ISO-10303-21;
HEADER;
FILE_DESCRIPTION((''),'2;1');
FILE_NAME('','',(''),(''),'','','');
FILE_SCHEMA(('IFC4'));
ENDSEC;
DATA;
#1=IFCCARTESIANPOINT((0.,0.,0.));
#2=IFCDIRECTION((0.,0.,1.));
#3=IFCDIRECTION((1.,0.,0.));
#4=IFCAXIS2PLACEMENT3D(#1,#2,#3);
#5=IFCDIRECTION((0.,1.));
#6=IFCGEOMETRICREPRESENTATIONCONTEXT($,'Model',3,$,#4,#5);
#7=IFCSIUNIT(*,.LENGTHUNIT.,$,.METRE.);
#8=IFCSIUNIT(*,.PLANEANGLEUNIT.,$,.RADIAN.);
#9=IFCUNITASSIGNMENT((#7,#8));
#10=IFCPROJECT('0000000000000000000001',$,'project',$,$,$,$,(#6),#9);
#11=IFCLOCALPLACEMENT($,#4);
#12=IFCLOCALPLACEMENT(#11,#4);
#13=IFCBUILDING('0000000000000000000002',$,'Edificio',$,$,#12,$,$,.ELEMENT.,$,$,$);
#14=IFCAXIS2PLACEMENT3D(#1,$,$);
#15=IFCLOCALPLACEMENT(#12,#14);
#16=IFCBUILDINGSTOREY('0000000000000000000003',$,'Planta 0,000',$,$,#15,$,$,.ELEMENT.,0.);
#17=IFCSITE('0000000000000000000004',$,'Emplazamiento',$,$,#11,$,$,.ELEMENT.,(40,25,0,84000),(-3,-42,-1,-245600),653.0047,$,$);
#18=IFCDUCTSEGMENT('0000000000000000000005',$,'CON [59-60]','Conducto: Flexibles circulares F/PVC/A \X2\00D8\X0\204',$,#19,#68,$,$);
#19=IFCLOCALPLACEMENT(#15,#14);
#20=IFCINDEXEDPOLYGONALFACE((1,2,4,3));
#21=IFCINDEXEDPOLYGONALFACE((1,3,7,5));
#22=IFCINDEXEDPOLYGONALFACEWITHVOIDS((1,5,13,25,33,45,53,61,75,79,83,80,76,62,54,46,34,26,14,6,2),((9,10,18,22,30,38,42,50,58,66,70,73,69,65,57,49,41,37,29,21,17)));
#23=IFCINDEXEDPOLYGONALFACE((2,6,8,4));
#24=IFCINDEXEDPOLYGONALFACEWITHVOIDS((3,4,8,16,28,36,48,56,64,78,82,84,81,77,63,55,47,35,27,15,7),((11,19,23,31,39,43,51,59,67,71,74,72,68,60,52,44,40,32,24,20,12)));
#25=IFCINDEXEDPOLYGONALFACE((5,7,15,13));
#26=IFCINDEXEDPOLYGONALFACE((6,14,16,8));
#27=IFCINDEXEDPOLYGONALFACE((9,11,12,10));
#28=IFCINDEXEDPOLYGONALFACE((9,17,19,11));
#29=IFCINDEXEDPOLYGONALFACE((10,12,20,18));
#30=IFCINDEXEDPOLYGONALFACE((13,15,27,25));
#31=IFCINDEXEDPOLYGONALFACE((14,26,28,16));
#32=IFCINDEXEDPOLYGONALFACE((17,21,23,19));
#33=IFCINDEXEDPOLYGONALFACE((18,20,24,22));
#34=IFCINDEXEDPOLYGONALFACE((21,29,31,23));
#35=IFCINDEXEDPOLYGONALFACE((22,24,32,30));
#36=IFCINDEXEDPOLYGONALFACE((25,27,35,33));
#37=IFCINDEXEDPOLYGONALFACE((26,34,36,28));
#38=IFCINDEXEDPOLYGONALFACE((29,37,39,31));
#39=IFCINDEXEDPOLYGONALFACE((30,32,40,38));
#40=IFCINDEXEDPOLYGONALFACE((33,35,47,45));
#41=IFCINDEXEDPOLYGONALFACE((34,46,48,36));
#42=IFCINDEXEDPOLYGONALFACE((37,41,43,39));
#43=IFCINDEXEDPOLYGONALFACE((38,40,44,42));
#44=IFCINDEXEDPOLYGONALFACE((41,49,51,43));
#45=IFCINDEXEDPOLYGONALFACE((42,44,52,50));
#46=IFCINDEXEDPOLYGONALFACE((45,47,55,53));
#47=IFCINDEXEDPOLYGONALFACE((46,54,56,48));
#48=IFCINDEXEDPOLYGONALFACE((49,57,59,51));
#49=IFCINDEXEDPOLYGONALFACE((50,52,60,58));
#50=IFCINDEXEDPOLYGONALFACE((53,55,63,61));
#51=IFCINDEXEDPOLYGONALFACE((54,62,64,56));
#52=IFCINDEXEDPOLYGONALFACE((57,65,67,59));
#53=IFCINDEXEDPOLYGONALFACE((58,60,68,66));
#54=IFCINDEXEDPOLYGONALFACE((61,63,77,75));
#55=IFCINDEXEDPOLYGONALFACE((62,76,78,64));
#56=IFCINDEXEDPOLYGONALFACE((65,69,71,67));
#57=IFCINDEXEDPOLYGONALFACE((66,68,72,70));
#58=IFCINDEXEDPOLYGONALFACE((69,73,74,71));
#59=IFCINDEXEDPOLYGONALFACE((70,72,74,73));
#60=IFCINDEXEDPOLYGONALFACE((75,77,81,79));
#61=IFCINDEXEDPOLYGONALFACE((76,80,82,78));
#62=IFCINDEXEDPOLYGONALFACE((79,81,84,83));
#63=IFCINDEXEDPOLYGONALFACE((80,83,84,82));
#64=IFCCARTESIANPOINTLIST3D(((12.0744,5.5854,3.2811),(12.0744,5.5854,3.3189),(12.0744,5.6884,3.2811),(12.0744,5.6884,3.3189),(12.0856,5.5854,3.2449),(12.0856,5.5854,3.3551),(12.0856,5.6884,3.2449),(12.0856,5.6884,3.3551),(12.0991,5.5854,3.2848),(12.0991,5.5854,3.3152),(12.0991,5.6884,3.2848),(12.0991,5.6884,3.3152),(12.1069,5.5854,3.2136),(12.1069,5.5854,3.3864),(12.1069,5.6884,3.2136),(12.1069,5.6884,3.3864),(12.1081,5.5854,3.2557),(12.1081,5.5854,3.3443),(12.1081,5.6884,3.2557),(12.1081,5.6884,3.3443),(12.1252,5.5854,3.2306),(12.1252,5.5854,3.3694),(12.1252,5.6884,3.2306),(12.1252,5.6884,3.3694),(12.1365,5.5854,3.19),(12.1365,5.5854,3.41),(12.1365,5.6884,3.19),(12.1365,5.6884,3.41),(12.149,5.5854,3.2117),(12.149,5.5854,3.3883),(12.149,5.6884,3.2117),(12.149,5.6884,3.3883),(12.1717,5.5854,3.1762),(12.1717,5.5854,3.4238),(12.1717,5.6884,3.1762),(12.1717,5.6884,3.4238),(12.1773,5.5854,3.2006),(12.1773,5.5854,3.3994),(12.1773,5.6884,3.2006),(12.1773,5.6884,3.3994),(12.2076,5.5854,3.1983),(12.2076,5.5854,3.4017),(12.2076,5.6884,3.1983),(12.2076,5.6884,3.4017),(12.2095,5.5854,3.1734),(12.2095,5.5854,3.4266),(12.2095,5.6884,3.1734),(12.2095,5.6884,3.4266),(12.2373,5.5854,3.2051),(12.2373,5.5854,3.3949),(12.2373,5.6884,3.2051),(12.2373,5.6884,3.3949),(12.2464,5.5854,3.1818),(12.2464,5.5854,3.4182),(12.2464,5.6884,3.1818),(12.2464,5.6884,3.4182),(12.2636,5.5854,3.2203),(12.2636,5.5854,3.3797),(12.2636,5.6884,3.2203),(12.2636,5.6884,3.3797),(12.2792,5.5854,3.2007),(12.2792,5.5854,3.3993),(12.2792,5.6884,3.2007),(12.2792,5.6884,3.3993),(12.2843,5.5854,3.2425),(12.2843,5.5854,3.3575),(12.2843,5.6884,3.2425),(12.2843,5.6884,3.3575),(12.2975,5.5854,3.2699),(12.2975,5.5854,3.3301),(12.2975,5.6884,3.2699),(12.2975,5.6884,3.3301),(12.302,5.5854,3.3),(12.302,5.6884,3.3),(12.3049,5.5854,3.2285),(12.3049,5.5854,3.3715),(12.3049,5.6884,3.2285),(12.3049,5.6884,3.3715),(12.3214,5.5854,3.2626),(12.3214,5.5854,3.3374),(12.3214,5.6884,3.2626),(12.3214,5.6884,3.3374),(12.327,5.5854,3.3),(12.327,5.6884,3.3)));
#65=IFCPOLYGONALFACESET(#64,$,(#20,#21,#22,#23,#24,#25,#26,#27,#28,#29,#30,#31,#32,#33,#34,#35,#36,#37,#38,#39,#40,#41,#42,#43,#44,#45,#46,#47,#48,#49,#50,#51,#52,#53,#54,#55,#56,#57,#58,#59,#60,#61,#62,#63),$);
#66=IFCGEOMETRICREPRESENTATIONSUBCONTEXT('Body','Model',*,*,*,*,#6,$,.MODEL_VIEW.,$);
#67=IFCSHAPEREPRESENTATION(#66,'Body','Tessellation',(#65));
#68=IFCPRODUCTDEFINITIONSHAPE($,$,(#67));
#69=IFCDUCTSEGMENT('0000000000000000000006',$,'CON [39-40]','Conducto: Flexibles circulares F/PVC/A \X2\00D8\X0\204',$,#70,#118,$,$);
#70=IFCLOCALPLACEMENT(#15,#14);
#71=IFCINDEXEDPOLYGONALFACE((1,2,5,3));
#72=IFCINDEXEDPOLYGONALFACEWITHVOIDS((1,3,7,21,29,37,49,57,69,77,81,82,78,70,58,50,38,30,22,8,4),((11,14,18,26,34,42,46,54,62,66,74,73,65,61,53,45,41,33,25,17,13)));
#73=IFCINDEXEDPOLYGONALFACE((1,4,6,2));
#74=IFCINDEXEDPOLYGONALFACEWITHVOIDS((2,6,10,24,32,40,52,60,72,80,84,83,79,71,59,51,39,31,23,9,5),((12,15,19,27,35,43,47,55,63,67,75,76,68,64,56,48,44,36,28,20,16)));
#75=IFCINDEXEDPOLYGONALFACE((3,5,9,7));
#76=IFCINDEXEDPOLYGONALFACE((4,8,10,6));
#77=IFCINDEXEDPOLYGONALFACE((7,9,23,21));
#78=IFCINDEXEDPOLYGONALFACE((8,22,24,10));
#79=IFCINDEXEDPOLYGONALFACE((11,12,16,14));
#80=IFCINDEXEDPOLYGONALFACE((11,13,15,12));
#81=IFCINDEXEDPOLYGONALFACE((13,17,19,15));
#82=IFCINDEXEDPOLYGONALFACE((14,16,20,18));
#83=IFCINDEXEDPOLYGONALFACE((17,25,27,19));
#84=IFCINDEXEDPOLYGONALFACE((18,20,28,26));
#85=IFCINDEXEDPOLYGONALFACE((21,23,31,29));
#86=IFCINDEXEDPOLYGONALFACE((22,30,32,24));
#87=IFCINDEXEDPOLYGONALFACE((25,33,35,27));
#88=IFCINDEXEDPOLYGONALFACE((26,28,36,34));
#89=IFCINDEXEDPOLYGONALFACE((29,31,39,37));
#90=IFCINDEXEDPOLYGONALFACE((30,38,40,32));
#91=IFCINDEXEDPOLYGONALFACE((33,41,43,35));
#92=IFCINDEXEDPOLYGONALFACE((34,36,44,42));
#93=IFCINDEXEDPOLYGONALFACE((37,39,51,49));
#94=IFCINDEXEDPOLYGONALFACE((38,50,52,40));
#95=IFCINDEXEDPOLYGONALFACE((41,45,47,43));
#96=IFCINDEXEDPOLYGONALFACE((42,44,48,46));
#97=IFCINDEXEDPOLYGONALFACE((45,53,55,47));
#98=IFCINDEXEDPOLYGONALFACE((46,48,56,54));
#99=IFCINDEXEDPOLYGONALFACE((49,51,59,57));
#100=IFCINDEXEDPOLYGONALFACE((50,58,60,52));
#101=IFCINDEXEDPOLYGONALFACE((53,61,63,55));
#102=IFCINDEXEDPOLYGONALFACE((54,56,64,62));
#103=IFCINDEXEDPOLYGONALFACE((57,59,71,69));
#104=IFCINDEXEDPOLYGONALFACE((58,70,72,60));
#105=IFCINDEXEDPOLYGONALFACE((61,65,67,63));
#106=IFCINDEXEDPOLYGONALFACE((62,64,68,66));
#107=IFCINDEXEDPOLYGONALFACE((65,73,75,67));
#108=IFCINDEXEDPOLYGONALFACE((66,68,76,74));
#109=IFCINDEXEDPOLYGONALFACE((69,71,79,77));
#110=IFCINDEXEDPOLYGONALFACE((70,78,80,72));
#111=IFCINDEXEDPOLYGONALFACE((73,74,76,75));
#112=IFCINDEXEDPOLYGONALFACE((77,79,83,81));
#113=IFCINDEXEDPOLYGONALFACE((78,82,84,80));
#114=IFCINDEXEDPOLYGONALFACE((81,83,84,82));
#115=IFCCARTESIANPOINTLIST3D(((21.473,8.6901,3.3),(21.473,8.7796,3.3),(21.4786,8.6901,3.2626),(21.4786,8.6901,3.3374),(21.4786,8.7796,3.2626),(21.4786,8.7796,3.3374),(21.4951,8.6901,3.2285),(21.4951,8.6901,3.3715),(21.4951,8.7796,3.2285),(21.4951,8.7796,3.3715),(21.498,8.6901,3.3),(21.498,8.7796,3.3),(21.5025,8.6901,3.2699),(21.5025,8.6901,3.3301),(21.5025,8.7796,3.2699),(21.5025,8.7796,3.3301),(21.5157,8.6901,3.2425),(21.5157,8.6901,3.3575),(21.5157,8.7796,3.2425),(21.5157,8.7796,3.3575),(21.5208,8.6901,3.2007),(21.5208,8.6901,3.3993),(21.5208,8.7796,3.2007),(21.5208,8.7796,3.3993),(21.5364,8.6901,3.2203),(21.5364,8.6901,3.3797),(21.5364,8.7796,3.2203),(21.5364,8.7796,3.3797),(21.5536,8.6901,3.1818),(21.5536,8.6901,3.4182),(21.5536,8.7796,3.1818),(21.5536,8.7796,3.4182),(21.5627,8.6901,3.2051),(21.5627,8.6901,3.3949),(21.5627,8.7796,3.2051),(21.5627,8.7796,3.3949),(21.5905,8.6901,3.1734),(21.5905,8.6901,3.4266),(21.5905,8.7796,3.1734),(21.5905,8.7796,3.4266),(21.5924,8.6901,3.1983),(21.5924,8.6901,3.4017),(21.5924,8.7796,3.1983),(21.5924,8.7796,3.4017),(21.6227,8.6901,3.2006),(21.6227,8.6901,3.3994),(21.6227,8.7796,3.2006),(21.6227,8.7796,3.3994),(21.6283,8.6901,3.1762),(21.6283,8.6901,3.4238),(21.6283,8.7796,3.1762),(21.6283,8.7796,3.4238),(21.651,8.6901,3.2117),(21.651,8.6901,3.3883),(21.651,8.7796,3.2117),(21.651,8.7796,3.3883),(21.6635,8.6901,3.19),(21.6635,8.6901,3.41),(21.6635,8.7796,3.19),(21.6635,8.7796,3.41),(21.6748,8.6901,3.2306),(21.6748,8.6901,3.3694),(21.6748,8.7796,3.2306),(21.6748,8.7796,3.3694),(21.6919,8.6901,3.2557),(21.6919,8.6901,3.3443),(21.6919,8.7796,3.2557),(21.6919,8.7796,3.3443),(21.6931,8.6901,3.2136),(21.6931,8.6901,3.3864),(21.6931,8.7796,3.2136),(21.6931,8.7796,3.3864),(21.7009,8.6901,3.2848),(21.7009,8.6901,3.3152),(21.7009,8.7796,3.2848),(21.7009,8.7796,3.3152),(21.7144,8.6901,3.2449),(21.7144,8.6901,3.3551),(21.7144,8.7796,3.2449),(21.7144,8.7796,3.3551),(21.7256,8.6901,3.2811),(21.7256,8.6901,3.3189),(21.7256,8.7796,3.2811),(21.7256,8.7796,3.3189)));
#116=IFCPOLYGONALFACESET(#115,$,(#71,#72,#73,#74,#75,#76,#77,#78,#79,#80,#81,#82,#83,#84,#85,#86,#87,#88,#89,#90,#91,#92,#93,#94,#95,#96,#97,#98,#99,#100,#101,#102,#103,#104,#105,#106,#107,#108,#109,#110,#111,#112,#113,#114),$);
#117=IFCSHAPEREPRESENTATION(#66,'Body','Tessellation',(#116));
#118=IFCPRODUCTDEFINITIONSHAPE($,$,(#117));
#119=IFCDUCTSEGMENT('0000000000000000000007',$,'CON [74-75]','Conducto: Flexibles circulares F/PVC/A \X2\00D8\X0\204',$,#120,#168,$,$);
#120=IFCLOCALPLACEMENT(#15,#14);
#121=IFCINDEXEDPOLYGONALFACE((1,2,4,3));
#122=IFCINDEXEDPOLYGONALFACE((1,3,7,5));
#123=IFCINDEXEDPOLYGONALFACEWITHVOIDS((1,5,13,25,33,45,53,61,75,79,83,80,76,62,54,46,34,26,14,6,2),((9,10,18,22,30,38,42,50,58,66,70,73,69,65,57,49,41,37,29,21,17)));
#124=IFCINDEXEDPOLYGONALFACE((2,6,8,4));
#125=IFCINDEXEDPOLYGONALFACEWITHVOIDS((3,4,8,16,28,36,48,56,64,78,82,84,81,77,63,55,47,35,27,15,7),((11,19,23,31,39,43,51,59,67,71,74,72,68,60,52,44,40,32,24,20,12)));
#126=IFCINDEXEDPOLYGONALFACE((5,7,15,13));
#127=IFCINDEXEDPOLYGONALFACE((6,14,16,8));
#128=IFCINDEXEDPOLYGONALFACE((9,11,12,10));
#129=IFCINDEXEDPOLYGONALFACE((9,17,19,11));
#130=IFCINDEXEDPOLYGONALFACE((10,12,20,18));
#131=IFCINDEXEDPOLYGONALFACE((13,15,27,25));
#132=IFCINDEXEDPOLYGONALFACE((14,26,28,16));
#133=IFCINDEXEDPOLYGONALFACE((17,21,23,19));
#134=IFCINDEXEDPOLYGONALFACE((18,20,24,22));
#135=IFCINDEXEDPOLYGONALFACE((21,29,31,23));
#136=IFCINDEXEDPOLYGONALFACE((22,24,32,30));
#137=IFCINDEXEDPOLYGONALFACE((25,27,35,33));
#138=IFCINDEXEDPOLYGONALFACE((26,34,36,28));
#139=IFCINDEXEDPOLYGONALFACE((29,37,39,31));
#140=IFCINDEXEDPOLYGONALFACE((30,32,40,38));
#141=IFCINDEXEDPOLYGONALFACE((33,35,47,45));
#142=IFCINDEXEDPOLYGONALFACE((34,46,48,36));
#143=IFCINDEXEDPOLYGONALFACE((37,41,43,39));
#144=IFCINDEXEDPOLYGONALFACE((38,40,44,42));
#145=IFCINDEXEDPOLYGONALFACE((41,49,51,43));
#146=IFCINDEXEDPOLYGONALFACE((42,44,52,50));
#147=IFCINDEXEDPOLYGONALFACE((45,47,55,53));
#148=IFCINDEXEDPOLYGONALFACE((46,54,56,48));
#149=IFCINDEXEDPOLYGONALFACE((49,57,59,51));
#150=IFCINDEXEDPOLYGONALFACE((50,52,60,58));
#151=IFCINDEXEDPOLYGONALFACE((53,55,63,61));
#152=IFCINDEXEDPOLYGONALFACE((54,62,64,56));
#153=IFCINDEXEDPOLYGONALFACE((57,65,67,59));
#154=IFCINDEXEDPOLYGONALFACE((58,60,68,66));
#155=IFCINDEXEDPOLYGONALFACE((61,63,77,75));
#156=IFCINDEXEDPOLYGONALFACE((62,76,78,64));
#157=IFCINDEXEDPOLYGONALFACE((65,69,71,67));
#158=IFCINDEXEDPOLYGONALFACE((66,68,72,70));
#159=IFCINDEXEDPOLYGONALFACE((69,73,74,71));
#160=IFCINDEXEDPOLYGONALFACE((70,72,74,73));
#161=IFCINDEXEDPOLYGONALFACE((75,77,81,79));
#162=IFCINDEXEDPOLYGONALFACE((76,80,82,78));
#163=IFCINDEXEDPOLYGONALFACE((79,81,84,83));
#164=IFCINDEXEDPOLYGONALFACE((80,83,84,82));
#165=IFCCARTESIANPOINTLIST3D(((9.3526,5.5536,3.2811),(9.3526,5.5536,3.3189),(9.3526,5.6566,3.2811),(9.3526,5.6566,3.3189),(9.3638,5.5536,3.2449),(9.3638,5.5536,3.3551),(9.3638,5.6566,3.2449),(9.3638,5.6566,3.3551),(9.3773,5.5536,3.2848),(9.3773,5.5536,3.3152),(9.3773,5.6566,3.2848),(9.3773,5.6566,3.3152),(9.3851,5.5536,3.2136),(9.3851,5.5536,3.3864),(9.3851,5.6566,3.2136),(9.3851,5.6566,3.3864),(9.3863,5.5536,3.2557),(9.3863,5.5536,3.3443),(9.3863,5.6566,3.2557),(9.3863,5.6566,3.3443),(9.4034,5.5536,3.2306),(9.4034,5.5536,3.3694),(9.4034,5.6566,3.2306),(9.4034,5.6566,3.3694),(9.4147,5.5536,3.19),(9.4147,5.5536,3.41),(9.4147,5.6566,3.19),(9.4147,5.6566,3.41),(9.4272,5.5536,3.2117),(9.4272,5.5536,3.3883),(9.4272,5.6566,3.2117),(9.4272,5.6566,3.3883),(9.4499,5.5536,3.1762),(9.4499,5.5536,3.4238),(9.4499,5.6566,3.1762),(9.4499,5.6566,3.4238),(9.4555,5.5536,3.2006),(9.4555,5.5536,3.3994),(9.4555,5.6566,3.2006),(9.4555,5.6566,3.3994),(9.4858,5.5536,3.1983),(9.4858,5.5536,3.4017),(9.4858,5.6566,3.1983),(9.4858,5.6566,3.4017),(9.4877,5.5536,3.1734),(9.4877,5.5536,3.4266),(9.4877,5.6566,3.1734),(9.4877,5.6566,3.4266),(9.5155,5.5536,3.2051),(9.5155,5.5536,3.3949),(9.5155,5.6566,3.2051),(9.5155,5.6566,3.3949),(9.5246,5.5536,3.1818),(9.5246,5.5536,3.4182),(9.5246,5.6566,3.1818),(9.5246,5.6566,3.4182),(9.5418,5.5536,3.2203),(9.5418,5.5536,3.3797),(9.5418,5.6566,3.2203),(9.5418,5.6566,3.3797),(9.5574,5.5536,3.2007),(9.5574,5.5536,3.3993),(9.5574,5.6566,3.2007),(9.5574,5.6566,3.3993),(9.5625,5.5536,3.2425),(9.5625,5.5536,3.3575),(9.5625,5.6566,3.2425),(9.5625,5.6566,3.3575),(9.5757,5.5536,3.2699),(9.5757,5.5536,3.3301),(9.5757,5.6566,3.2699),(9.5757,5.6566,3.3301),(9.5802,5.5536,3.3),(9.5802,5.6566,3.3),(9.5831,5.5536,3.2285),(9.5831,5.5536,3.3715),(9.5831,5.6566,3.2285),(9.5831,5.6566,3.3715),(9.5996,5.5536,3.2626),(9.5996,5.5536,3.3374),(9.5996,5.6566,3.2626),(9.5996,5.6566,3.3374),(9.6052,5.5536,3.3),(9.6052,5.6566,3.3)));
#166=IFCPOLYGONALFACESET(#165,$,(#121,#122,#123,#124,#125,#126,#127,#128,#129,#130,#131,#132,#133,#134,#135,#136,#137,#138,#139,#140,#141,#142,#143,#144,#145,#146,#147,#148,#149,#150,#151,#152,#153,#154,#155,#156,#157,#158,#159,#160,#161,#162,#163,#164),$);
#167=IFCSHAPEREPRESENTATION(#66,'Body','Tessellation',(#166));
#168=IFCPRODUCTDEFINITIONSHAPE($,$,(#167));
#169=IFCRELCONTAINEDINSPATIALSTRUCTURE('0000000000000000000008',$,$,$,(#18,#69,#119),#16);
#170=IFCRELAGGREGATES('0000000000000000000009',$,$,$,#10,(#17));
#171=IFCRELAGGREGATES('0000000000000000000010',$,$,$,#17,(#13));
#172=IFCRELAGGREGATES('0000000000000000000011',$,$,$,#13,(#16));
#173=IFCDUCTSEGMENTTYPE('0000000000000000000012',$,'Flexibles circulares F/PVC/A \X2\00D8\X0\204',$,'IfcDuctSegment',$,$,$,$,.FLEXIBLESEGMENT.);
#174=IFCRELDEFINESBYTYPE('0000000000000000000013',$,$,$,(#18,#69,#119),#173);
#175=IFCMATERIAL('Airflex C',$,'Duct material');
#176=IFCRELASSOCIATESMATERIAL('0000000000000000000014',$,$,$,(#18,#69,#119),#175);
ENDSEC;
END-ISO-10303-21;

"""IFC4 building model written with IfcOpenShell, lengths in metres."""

from ifc_helpers import new_model, si_unit, direction, frame, origin, origin_with_axes, origin_2d_with_axis, place, context, subcontext, project, spatial, hollow_circle, extrude, material, type_object, element, save


model = new_model("IFC4")

# Units and contexts
model_context = context("Model", 3, world=origin_with_axes(), true_north=direction((0.0, 1.0)))
body_context = subcontext(model_context, "Body", "Model", "MODEL_VIEW")
ifc_project = project(units=[si_unit("LENGTHUNIT", "METRE"), si_unit("PLANEANGLEUNIT", "RADIAN")], contexts=[model_context])

# Site, building, storey
site_placement = place(None, origin_with_axes())
site = spatial("IfcSite", under=ifc_project, at=site_placement, Name="Emplazamiento", CompositionType="ELEMENT", RefLatitude=(40, 25, 0, 84000), RefLongitude=(-3, -42, -1, -245600), RefElevation=653.0047)
building_placement = place(site_placement, origin_with_axes())
building = spatial("IfcBuilding", under=site, at=building_placement, Name="Edificio", CompositionType="ELEMENT")
storey_placement = place(building_placement, origin())
storey = spatial("IfcBuildingStorey", under=building, at=storey_placement, Name="Planta 0,000", CompositionType="ELEMENT", Elevation=0.0)

# Shared definitions
ifc_material_1 = material(Name="Airflex C", Category="Duct material")

# Duct segments
duct_segment_type_1 = type_object("IfcDuctSegmentType", Name="Flexibles circulares F/PVC/A Ø204", ApplicableOccurrence="IfcDuctSegment", PredefinedType="FLEXIBLESEGMENT")
duct_segment_1_placement = place(storey_placement, origin_with_axes())
element("IfcDuctSegment", 1, at=duct_segment_1_placement, inside=storey, type_object=duct_segment_type_1, material=ifc_material_1, Name="CON [59-60]", Description="Conducto: Flexibles circulares F/PVC/A Ø204", context=body_context, shape_type="SweptSolid", body=[
    extrude(hollow_circle(Radius=0.127, WallThickness=0.025, at=origin_2d_with_axis()), frame((12.2, 5.6884, 3.3), z_axis=(0.0, -1.0, 0.0), x_axis=(1.0, 0.0, 0.0)), (0.0, 0.0, 1.0), 0.103),
])
duct_segment_2_placement = place(storey_placement, origin_with_axes())
element("IfcDuctSegment", 2, at=duct_segment_2_placement, inside=storey, type_object=duct_segment_type_1, material=ifc_material_1, Name="CON [39-40]", Description="Conducto: Flexibles circulares F/PVC/A Ø204", context=body_context, shape_type="SweptSolid", body=[
    extrude(hollow_circle(Radius=0.127, WallThickness=0.025, at=origin_2d_with_axis()), frame((21.6, 8.6901, 3.3), z_axis=(0.0, 1.0, 0.0), x_axis=(-1.0, 0.0, 0.0)), (0.0, 0.0, 1.0), 0.0895),
])
duct_segment_3_placement = place(storey_placement, origin_with_axes())
element("IfcDuctSegment", 3, at=duct_segment_3_placement, inside=storey, type_object=duct_segment_type_1, material=ifc_material_1, Name="CON [74-75]", Description="Conducto: Flexibles circulares F/PVC/A Ø204", context=body_context, shape_type="SweptSolid", body=[
    extrude(hollow_circle(Radius=0.127, WallThickness=0.025, at=origin_2d_with_axis()), frame((9.4782, 5.6566, 3.3), z_axis=(0.0, -1.0, 0.0), x_axis=(1.0, 0.0, 0.0)), (0.0, 0.0, 1.0), 0.103),
])

save(model, "model.ifc")
